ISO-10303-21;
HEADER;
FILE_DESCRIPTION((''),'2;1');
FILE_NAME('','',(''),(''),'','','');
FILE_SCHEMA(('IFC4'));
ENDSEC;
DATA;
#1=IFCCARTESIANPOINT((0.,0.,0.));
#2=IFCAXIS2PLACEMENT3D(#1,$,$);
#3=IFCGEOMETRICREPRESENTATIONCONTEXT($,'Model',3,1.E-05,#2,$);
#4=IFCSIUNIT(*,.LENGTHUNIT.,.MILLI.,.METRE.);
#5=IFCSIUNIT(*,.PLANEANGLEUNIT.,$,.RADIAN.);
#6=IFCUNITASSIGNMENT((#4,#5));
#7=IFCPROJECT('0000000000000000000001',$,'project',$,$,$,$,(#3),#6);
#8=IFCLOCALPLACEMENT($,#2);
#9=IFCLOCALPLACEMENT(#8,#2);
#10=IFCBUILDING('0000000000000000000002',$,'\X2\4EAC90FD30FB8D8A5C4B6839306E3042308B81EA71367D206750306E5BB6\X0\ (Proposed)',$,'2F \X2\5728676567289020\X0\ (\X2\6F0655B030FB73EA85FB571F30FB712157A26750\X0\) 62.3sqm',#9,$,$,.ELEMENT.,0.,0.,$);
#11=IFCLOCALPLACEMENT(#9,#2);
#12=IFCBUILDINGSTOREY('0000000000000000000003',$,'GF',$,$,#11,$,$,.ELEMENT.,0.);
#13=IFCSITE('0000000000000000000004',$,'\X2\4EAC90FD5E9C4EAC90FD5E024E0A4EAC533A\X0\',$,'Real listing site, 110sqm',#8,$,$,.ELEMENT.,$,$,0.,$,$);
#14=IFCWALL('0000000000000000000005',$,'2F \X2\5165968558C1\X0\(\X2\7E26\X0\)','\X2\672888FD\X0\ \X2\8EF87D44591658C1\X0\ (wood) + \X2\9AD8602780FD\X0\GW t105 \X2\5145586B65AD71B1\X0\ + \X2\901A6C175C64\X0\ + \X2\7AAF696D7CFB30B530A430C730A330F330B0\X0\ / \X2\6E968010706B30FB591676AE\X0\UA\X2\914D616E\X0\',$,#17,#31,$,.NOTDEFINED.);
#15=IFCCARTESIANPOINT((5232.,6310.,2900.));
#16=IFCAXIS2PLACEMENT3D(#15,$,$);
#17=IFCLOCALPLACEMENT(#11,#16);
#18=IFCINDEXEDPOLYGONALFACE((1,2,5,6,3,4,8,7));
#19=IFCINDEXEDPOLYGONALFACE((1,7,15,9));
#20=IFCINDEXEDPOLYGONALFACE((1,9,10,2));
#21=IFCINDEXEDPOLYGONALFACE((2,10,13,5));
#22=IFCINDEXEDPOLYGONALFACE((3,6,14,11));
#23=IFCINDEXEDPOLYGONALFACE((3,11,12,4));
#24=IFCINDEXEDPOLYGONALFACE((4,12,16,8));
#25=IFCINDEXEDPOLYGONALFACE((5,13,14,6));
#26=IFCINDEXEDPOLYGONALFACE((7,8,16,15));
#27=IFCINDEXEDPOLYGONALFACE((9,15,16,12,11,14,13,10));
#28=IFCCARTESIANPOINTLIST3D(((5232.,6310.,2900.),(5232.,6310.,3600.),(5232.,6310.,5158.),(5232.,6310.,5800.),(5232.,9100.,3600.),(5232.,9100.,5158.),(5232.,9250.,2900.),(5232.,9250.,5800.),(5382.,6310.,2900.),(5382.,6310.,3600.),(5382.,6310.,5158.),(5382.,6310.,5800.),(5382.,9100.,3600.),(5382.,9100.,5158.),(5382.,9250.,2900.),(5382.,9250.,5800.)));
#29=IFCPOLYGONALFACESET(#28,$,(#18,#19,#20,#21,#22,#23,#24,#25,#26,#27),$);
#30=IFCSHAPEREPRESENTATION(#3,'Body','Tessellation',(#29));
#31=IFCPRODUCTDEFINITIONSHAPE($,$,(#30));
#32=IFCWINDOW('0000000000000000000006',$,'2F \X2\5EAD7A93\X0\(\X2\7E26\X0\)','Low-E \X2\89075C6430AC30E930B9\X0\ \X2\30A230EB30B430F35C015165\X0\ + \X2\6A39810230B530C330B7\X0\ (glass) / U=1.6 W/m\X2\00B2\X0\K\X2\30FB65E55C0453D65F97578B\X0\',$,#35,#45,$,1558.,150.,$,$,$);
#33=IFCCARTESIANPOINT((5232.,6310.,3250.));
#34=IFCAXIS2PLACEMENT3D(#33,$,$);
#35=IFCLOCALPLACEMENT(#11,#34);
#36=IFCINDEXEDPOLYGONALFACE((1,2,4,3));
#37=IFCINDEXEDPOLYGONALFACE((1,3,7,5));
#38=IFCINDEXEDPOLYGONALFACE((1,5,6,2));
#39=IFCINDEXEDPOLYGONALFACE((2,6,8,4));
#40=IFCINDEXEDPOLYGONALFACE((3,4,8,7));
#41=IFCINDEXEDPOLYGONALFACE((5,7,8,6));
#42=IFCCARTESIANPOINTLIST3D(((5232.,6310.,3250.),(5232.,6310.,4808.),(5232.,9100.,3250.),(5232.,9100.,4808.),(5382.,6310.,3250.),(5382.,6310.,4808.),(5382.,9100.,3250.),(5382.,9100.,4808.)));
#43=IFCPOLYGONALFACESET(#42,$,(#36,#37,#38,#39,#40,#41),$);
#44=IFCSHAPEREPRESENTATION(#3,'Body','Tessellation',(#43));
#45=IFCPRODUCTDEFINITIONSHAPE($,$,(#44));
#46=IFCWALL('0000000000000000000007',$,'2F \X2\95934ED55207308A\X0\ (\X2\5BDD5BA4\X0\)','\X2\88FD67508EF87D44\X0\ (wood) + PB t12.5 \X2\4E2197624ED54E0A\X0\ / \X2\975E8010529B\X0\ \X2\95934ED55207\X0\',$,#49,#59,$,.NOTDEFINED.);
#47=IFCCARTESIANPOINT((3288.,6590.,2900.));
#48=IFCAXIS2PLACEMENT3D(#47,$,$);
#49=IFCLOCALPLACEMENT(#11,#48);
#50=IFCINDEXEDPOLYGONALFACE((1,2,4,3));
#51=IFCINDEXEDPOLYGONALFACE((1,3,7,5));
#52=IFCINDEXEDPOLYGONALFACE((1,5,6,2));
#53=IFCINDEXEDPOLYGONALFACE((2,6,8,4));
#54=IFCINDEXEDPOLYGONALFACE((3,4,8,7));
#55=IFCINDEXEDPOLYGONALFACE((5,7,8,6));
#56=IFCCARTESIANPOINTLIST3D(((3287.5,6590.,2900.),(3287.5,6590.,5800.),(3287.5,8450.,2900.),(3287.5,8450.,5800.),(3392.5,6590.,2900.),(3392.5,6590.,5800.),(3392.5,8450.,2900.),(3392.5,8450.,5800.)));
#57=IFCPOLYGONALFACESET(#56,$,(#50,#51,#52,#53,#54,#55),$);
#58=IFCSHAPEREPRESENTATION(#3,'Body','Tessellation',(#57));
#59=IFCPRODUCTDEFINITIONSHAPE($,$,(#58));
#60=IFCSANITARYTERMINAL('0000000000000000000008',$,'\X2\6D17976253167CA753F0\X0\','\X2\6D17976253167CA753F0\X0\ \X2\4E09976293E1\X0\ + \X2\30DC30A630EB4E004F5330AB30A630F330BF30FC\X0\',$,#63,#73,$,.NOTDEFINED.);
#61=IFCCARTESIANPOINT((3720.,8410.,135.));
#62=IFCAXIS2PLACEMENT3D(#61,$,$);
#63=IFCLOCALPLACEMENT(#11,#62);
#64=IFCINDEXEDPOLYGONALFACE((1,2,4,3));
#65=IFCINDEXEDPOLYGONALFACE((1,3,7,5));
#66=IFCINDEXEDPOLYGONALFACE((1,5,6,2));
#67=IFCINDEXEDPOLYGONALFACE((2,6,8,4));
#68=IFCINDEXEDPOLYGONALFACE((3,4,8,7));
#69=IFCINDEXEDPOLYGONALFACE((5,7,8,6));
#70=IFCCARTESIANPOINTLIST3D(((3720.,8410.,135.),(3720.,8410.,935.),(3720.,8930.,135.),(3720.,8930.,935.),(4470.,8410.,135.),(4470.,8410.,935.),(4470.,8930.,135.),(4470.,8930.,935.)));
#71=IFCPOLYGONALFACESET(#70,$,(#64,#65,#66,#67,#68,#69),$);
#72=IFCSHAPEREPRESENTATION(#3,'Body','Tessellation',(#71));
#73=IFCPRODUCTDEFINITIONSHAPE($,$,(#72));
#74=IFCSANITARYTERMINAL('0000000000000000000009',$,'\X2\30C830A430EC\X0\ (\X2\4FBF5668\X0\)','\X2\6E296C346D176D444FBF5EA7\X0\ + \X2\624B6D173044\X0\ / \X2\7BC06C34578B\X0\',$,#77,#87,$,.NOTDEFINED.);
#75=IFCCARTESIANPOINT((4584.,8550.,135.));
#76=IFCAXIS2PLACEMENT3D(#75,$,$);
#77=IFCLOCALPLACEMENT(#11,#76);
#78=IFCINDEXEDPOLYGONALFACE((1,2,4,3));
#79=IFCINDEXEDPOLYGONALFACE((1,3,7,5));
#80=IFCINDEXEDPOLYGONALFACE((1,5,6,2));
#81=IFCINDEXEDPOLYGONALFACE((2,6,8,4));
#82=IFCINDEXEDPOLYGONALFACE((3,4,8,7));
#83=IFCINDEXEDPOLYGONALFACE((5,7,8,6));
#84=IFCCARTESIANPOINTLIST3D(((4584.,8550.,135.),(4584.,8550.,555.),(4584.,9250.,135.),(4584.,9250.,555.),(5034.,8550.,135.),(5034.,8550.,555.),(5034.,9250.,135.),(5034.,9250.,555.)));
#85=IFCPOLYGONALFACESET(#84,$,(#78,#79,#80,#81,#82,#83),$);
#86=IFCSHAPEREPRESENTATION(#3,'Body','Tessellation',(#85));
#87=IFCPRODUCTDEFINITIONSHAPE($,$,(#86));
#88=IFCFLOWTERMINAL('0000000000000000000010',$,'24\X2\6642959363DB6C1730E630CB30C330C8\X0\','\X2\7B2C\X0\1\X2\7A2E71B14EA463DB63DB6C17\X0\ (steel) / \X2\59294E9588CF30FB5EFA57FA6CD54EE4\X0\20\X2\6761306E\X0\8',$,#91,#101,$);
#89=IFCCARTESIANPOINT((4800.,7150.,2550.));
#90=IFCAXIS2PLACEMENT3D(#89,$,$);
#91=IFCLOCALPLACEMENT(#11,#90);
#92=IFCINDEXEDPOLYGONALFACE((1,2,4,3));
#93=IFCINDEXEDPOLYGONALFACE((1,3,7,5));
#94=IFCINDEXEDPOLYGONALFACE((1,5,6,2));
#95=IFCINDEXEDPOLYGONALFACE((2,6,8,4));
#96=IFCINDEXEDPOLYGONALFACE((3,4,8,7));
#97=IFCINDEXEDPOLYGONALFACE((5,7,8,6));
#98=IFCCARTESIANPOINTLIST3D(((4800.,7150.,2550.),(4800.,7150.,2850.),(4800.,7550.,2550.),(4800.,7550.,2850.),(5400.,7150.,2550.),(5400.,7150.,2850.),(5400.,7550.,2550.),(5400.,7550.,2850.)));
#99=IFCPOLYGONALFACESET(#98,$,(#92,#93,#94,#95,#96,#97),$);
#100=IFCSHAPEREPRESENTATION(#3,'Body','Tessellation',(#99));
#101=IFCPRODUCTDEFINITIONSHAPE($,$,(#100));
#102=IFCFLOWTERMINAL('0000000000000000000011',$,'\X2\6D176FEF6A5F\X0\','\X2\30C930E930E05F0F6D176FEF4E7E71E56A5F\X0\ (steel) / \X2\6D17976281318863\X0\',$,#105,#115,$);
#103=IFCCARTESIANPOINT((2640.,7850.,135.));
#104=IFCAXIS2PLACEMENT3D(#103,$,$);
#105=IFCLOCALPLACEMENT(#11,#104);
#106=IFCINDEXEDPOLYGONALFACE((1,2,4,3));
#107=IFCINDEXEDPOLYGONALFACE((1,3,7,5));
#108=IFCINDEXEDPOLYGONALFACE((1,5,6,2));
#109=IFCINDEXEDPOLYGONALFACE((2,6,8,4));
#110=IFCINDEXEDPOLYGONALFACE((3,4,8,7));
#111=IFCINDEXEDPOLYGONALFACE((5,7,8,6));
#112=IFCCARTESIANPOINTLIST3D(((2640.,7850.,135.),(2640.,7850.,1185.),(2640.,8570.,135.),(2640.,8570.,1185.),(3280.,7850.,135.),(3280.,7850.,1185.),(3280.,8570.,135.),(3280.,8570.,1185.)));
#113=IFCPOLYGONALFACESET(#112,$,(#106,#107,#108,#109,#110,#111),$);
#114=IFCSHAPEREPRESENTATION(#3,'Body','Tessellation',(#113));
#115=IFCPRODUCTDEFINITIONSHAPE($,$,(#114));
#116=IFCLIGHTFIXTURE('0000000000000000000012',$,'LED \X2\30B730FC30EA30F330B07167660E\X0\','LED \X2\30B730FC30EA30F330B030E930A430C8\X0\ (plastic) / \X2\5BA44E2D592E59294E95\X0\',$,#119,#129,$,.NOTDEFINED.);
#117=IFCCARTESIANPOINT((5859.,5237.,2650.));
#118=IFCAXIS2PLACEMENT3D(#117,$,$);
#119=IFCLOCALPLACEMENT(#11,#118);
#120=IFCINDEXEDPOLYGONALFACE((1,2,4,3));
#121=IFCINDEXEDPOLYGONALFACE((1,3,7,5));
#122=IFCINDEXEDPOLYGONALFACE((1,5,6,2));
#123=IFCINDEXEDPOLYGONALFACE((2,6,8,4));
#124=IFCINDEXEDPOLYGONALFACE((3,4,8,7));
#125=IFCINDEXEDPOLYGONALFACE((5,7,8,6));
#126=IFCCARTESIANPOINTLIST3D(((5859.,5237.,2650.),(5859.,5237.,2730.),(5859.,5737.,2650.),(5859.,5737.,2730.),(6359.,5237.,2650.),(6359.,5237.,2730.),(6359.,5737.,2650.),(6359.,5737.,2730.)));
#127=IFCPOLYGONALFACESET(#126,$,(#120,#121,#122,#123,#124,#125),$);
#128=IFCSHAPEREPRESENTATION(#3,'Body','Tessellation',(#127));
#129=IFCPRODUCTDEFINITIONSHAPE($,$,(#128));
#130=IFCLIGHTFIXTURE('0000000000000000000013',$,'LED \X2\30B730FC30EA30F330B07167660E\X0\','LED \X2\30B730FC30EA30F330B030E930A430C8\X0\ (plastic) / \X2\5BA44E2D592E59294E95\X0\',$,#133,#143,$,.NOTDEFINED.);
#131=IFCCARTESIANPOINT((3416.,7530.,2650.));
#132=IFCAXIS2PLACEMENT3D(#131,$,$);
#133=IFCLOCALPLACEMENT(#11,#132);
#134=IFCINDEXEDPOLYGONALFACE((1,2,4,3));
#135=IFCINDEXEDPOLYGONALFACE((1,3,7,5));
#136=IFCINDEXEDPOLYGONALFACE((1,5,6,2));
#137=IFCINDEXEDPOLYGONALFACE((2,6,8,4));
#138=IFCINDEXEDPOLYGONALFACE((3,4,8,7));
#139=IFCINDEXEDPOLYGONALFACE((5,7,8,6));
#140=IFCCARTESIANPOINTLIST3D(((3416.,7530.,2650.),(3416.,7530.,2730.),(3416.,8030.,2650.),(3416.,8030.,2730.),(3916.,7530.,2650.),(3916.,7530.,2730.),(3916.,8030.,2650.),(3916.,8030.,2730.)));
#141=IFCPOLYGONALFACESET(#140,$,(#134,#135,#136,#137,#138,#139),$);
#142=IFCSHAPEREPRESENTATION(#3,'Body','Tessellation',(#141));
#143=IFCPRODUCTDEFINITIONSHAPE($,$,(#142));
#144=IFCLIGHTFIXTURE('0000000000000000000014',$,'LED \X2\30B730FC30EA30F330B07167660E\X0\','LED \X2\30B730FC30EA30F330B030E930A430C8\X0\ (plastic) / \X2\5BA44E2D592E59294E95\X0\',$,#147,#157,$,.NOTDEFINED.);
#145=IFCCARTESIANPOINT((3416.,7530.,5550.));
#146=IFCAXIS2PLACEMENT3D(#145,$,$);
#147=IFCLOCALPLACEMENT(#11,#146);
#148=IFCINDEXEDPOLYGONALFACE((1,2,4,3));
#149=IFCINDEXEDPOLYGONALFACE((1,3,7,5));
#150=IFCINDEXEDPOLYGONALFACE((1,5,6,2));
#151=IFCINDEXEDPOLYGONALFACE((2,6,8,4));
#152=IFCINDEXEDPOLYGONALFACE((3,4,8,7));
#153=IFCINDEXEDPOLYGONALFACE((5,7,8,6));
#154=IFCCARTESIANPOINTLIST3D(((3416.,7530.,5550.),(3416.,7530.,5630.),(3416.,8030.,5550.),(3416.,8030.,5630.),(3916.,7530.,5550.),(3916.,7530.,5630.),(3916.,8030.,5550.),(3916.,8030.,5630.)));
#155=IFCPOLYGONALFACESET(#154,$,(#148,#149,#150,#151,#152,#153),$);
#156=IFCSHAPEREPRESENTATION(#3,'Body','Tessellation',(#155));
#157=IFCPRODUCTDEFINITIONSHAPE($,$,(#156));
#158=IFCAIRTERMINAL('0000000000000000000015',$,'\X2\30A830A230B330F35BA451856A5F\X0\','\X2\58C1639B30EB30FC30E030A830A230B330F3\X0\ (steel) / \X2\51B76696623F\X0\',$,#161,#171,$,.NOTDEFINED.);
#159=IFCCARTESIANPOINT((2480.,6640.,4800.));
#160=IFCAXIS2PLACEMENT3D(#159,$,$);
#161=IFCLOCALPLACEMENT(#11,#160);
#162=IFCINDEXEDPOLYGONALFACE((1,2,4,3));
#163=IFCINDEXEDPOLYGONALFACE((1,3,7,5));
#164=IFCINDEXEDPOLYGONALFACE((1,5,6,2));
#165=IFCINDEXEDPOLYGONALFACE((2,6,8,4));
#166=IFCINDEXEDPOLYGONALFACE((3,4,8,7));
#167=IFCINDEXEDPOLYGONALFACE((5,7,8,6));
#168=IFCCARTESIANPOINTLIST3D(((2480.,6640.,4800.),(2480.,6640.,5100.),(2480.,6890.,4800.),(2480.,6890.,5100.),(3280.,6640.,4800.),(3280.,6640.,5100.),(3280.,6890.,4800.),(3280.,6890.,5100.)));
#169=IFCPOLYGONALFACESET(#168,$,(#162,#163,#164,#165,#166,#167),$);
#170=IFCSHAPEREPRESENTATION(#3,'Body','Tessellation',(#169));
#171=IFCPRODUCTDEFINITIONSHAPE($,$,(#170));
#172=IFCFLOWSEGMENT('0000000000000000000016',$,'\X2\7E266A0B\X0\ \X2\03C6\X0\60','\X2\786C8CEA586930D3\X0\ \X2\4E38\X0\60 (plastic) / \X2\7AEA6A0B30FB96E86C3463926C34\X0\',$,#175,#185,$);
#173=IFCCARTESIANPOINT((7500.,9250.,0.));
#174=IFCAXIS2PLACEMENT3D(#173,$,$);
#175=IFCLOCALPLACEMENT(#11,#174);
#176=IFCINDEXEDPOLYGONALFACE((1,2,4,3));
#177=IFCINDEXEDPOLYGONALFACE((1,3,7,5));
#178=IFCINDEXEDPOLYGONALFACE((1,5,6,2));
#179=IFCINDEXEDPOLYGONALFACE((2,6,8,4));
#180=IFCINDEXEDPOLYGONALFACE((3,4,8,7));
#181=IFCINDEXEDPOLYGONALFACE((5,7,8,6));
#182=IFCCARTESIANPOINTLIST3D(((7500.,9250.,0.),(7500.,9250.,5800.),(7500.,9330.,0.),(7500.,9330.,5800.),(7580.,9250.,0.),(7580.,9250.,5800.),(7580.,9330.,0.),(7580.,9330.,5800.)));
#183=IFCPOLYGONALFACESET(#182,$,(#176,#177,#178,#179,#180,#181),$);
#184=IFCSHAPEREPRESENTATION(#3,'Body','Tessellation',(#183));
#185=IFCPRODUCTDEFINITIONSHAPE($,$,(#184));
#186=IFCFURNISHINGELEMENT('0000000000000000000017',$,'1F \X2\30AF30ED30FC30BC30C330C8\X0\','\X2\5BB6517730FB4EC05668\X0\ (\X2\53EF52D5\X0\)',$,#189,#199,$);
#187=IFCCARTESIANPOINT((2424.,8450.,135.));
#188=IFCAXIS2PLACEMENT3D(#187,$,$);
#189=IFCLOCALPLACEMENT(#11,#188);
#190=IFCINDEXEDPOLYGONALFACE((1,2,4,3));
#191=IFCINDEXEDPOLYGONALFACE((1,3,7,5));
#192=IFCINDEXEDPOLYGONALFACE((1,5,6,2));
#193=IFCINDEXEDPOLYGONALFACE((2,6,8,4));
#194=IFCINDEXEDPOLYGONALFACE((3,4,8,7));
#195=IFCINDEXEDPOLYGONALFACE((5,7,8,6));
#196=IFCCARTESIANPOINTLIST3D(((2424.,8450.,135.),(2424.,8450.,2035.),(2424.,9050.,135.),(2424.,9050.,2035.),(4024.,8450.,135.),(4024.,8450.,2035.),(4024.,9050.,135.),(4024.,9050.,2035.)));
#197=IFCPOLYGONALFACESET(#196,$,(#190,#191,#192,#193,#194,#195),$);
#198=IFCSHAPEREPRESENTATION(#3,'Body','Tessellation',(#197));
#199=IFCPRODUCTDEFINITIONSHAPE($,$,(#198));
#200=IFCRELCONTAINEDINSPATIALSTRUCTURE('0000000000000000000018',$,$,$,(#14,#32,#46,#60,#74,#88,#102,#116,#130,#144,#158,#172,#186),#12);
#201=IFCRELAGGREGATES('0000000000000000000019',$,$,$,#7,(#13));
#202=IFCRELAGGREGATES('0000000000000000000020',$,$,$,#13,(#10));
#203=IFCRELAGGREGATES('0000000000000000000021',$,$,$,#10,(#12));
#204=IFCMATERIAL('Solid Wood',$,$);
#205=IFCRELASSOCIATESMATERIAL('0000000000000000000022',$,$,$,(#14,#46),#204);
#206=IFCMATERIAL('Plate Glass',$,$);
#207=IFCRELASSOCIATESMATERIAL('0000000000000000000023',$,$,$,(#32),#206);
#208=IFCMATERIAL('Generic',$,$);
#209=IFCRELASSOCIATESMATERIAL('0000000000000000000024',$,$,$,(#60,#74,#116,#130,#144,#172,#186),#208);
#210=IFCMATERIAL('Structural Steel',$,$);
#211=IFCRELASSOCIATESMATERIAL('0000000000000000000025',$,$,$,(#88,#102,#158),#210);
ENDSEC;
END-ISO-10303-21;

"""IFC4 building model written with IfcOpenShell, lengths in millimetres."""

from ifc_helpers import new_model, si_unit, frame, frame_2d, origin, place, context, project, spatial, rectangle, extrude, material, element, fill, save


model = new_model("IFC4")

# Units and contexts
model_context = context("Model", 3, precision=1e-05, world=origin())
ifc_project = project(units=[si_unit("LENGTHUNIT", "METRE", prefix="MILLI"), si_unit("PLANEANGLEUNIT", "RADIAN")], contexts=[model_context])

# Site, building, storey
site_placement = place(None, origin())
site = spatial("IfcSite", under=ifc_project, at=site_placement, Name="京都府京都市上京区", ObjectType="Real listing site, 110sqm", CompositionType="ELEMENT", RefElevation=0.0)
building_placement = place(site_placement, origin())
building = spatial("IfcBuilding", under=site, at=building_placement, Name="京都・越屋根のある自然素材の家 (Proposed)", ObjectType="2F 在来木造 (漆喰・珪藻土・無垢材) 62.3sqm", CompositionType="ELEMENT", ElevationOfRefHeight=0.0, ElevationOfTerrain=0.0)
storey_placement = place(building_placement, origin())
storey = spatial("IfcBuildingStorey", under=building, at=storey_placement, Name="GF", CompositionType="ELEMENT", Elevation=0.0)

# Shared definitions
ifc_material_1 = material(Name="Solid Wood")

# Shared definitions
ifc_material_2 = material(Name="Plate Glass")

# Wall, opening, window
wall_1_placement = place(storey_placement, frame((5232.0, 6310.0, 2900.0)))
wall_1 = element("IfcWall", 1, at=wall_1_placement, inside=storey, material=ifc_material_1, Name="2F 入隅壁(縦)", Description="木製 軸組外壁 (wood) + 高性能GW t105 充填断熱 + 通気層 + 窯業系サイディング / 準耐火・外皮UA配慮", PredefinedType="NOTDEFINED", context=model_context, shape_type="SweptSolid", body=[
    extrude(rectangle(XDim=150.0, YDim=2940.0, at=frame_2d((75.0, 1470.0))), frame((5232.0, 6310.0, 2900.0)), (0.0, 0.0, 1.0), 2900.0),
])
opening_1_placement = place(storey_placement, frame((5232.0, 6310.0, 3250.0)))
opening_1 = element("IfcOpeningElement", 2, at=opening_1_placement, cuts=wall_1, PredefinedType="NOTDEFINED", context=model_context, shape_type="SweptSolid", body=[
    extrude(rectangle(XDim=150.0, YDim=2790.0, at=frame_2d((75.0, 1395.0))), frame((5232.0, 6310.0, 3250.0)), (0.0, 0.0, 1.0), 1558.0),
])
window_1_placement = place(storey_placement, frame((5232.0, 6310.0, 3250.0)))
window_1 = element("IfcWindow", 3, at=window_1_placement, inside=storey, material=ifc_material_2, Name="2F 庭窓(縦)", Description="Low-E 複層ガラス アルゴン封入 + 樹脂サッシ (glass) / U=1.6 W/m²K・日射取得型", OverallHeight=1558.0, OverallWidth=150.0, context=model_context, shape_type="SweptSolid", body=[
    extrude(rectangle(XDim=150.0, YDim=2790.0, at=frame_2d((75.0, 1395.0))), frame((5232.0, 6310.0, 3250.0)), (0.0, 0.0, 1.0), 1558.0),
])
fill(opening_1, window_1)

# Wall
wall_2_placement = place(storey_placement, frame((3288.0, 6590.0, 2900.0)))
element("IfcWall", 4, at=wall_2_placement, inside=storey, material=ifc_material_1, Name="2F 間仕切り (寝室)", Description="製材軸組 (wood) + PB t12.5 両面仕上 / 非耐力 間仕切", PredefinedType="NOTDEFINED", context=model_context, shape_type="SweptSolid", body=[
    extrude(rectangle(XDim=105.0, YDim=1860.0, at=frame_2d((52.0, 930.0))), frame((3288.0, 6590.0, 2900.0)), (0.0, 0.0, 1.0), 2900.0),
])

# Sanitary terminals
ifc_material_3 = material(Name="Generic")
sanitary_terminal_1_placement = place(storey_placement, frame((3720.0, 8410.0, 135.0)))
element("IfcSanitaryTerminal", 5, at=sanitary_terminal_1_placement, inside=storey, material=ifc_material_3, Name="洗面化粧台", Description="洗面化粧台 三面鏡 + ボウル一体カウンター", PredefinedType="NOTDEFINED", context=model_context, shape_type="SweptSolid", body=[
    extrude(rectangle(XDim=750.0, YDim=520.0, at=frame_2d((375.0, 260.0))), frame((3720.0, 8410.0, 135.0)), (0.0, 0.0, 1.0), 800.0),
])
sanitary_terminal_2_placement = place(storey_placement, frame((4584.0, 8550.0, 135.0)))
element("IfcSanitaryTerminal", 6, at=sanitary_terminal_2_placement, inside=storey, material=ifc_material_3, Name="トイレ (便器)", Description="温水洗浄便座 + 手洗い / 節水型", PredefinedType="NOTDEFINED", context=model_context, shape_type="SweptSolid", body=[
    extrude(rectangle(XDim=450.0, YDim=700.0, at=frame_2d((225.0, 350.0))), frame((4584.0, 8550.0, 135.0)), (0.0, 0.0, 1.0), 420.0),
])

# Flow terminals
ifc_material_4 = material(Name="Structural Steel")
flow_terminal_1_placement = place(storey_placement, frame((4800.0, 7150.0, 2550.0)))
element("IfcFlowTerminal", 7, at=flow_terminal_1_placement, inside=storey, material=ifc_material_4, Name="24時間換気ユニット", Description="第1種熱交換換気 (steel) / 天井裏・建基法令20条の8", context=model_context, shape_type="SweptSolid", body=[
    extrude(rectangle(XDim=600.0, YDim=400.0, at=frame_2d((300.0, 200.0))), frame((4800.0, 7150.0, 2550.0)), (0.0, 0.0, 1.0), 300.0),
])
flow_terminal_2_placement = place(storey_placement, frame((2640.0, 7850.0, 135.0)))
element("IfcFlowTerminal", 8, at=flow_terminal_2_placement, inside=storey, material=ifc_material_4, Name="洗濯機", Description="ドラム式洗濯乾燥機 (steel) / 洗面脱衣", context=model_context, shape_type="SweptSolid", body=[
    extrude(rectangle(XDim=640.0, YDim=720.0, at=frame_2d((320.0, 360.0))), frame((2640.0, 7850.0, 135.0)), (0.0, 0.0, 1.0), 1050.0),
])

# Light fixtures
light_fixture_1_placement = place(storey_placement, frame((5859.0, 5237.0, 2650.0)))
element("IfcLightFixture", 9, at=light_fixture_1_placement, inside=storey, material=ifc_material_3, Name="LED シーリング照明", Description="LED シーリングライト (plastic) / 室中央天井", PredefinedType="NOTDEFINED", context=model_context, shape_type="SweptSolid", body=[
    extrude(rectangle(XDim=500.0, YDim=500.0, at=frame_2d((250.0, 250.0))), frame((5859.0, 5237.0, 2650.0)), (0.0, 0.0, 1.0), 80.0),
])
light_fixture_2_placement = place(storey_placement, frame((3416.0, 7530.0, 2650.0)))
element("IfcLightFixture", 10, at=light_fixture_2_placement, inside=storey, material=ifc_material_3, Name="LED シーリング照明", Description="LED シーリングライト (plastic) / 室中央天井", PredefinedType="NOTDEFINED", context=model_context, shape_type="SweptSolid", body=[
    extrude(rectangle(XDim=500.0, YDim=500.0, at=frame_2d((250.0, 250.0))), frame((3416.0, 7530.0, 2650.0)), (0.0, 0.0, 1.0), 80.0),
])
light_fixture_3_placement = place(storey_placement, frame((3416.0, 7530.0, 5550.0)))
element("IfcLightFixture", 11, at=light_fixture_3_placement, inside=storey, material=ifc_material_3, Name="LED シーリング照明", Description="LED シーリングライト (plastic) / 室中央天井", PredefinedType="NOTDEFINED", context=model_context, shape_type="SweptSolid", body=[
    extrude(rectangle(XDim=500.0, YDim=500.0, at=frame_2d((250.0, 250.0))), frame((3416.0, 7530.0, 5550.0)), (0.0, 0.0, 1.0), 80.0),
])

# Air terminal
air_terminal_placement = place(storey_placement, frame((2480.0, 6640.0, 4800.0)))
element("IfcAirTerminal", 12, at=air_terminal_placement, inside=storey, material=ifc_material_4, Name="エアコン室内機", Description="壁掛ルームエアコン (steel) / 冷暖房", PredefinedType="NOTDEFINED", context=model_context, shape_type="SweptSolid", body=[
    extrude(rectangle(XDim=800.0, YDim=250.0, at=frame_2d((400.0, 125.0))), frame((2480.0, 6640.0, 4800.0)), (0.0, 0.0, 1.0), 300.0),
])

# Flow segment
flow_segment_placement = place(storey_placement, frame((7500.0, 9250.0, 0.0)))
element("IfcFlowSegment", 13, at=flow_segment_placement, inside=storey, material=ifc_material_3, Name="縦樋 φ60", Description="硬質塩ビ 丸60 (plastic) / 竪樋・雨水排水", context=model_context, shape_type="SweptSolid", body=[
    extrude(rectangle(XDim=80.0, YDim=80.0, at=frame_2d((40.0, 40.0))), frame((7500.0, 9250.0, 0.0)), (0.0, 0.0, 1.0), 5800.0),
])

# Furnishing element
furnishing_1_placement = place(storey_placement, frame((2424.0, 8450.0, 135.0)))
element("IfcFurnishingElement", 14, at=furnishing_1_placement, inside=storey, material=ifc_material_3, Name="1F クローゼット", Description="家具・什器 (可動)", context=model_context, shape_type="SweptSolid", body=[
    extrude(rectangle(XDim=1600.0, YDim=600.0, at=frame_2d((800.0, 300.0))), frame((2424.0, 8450.0, 135.0)), (0.0, 0.0, 1.0), 1900.0),
])

save(model, "model.ifc")
